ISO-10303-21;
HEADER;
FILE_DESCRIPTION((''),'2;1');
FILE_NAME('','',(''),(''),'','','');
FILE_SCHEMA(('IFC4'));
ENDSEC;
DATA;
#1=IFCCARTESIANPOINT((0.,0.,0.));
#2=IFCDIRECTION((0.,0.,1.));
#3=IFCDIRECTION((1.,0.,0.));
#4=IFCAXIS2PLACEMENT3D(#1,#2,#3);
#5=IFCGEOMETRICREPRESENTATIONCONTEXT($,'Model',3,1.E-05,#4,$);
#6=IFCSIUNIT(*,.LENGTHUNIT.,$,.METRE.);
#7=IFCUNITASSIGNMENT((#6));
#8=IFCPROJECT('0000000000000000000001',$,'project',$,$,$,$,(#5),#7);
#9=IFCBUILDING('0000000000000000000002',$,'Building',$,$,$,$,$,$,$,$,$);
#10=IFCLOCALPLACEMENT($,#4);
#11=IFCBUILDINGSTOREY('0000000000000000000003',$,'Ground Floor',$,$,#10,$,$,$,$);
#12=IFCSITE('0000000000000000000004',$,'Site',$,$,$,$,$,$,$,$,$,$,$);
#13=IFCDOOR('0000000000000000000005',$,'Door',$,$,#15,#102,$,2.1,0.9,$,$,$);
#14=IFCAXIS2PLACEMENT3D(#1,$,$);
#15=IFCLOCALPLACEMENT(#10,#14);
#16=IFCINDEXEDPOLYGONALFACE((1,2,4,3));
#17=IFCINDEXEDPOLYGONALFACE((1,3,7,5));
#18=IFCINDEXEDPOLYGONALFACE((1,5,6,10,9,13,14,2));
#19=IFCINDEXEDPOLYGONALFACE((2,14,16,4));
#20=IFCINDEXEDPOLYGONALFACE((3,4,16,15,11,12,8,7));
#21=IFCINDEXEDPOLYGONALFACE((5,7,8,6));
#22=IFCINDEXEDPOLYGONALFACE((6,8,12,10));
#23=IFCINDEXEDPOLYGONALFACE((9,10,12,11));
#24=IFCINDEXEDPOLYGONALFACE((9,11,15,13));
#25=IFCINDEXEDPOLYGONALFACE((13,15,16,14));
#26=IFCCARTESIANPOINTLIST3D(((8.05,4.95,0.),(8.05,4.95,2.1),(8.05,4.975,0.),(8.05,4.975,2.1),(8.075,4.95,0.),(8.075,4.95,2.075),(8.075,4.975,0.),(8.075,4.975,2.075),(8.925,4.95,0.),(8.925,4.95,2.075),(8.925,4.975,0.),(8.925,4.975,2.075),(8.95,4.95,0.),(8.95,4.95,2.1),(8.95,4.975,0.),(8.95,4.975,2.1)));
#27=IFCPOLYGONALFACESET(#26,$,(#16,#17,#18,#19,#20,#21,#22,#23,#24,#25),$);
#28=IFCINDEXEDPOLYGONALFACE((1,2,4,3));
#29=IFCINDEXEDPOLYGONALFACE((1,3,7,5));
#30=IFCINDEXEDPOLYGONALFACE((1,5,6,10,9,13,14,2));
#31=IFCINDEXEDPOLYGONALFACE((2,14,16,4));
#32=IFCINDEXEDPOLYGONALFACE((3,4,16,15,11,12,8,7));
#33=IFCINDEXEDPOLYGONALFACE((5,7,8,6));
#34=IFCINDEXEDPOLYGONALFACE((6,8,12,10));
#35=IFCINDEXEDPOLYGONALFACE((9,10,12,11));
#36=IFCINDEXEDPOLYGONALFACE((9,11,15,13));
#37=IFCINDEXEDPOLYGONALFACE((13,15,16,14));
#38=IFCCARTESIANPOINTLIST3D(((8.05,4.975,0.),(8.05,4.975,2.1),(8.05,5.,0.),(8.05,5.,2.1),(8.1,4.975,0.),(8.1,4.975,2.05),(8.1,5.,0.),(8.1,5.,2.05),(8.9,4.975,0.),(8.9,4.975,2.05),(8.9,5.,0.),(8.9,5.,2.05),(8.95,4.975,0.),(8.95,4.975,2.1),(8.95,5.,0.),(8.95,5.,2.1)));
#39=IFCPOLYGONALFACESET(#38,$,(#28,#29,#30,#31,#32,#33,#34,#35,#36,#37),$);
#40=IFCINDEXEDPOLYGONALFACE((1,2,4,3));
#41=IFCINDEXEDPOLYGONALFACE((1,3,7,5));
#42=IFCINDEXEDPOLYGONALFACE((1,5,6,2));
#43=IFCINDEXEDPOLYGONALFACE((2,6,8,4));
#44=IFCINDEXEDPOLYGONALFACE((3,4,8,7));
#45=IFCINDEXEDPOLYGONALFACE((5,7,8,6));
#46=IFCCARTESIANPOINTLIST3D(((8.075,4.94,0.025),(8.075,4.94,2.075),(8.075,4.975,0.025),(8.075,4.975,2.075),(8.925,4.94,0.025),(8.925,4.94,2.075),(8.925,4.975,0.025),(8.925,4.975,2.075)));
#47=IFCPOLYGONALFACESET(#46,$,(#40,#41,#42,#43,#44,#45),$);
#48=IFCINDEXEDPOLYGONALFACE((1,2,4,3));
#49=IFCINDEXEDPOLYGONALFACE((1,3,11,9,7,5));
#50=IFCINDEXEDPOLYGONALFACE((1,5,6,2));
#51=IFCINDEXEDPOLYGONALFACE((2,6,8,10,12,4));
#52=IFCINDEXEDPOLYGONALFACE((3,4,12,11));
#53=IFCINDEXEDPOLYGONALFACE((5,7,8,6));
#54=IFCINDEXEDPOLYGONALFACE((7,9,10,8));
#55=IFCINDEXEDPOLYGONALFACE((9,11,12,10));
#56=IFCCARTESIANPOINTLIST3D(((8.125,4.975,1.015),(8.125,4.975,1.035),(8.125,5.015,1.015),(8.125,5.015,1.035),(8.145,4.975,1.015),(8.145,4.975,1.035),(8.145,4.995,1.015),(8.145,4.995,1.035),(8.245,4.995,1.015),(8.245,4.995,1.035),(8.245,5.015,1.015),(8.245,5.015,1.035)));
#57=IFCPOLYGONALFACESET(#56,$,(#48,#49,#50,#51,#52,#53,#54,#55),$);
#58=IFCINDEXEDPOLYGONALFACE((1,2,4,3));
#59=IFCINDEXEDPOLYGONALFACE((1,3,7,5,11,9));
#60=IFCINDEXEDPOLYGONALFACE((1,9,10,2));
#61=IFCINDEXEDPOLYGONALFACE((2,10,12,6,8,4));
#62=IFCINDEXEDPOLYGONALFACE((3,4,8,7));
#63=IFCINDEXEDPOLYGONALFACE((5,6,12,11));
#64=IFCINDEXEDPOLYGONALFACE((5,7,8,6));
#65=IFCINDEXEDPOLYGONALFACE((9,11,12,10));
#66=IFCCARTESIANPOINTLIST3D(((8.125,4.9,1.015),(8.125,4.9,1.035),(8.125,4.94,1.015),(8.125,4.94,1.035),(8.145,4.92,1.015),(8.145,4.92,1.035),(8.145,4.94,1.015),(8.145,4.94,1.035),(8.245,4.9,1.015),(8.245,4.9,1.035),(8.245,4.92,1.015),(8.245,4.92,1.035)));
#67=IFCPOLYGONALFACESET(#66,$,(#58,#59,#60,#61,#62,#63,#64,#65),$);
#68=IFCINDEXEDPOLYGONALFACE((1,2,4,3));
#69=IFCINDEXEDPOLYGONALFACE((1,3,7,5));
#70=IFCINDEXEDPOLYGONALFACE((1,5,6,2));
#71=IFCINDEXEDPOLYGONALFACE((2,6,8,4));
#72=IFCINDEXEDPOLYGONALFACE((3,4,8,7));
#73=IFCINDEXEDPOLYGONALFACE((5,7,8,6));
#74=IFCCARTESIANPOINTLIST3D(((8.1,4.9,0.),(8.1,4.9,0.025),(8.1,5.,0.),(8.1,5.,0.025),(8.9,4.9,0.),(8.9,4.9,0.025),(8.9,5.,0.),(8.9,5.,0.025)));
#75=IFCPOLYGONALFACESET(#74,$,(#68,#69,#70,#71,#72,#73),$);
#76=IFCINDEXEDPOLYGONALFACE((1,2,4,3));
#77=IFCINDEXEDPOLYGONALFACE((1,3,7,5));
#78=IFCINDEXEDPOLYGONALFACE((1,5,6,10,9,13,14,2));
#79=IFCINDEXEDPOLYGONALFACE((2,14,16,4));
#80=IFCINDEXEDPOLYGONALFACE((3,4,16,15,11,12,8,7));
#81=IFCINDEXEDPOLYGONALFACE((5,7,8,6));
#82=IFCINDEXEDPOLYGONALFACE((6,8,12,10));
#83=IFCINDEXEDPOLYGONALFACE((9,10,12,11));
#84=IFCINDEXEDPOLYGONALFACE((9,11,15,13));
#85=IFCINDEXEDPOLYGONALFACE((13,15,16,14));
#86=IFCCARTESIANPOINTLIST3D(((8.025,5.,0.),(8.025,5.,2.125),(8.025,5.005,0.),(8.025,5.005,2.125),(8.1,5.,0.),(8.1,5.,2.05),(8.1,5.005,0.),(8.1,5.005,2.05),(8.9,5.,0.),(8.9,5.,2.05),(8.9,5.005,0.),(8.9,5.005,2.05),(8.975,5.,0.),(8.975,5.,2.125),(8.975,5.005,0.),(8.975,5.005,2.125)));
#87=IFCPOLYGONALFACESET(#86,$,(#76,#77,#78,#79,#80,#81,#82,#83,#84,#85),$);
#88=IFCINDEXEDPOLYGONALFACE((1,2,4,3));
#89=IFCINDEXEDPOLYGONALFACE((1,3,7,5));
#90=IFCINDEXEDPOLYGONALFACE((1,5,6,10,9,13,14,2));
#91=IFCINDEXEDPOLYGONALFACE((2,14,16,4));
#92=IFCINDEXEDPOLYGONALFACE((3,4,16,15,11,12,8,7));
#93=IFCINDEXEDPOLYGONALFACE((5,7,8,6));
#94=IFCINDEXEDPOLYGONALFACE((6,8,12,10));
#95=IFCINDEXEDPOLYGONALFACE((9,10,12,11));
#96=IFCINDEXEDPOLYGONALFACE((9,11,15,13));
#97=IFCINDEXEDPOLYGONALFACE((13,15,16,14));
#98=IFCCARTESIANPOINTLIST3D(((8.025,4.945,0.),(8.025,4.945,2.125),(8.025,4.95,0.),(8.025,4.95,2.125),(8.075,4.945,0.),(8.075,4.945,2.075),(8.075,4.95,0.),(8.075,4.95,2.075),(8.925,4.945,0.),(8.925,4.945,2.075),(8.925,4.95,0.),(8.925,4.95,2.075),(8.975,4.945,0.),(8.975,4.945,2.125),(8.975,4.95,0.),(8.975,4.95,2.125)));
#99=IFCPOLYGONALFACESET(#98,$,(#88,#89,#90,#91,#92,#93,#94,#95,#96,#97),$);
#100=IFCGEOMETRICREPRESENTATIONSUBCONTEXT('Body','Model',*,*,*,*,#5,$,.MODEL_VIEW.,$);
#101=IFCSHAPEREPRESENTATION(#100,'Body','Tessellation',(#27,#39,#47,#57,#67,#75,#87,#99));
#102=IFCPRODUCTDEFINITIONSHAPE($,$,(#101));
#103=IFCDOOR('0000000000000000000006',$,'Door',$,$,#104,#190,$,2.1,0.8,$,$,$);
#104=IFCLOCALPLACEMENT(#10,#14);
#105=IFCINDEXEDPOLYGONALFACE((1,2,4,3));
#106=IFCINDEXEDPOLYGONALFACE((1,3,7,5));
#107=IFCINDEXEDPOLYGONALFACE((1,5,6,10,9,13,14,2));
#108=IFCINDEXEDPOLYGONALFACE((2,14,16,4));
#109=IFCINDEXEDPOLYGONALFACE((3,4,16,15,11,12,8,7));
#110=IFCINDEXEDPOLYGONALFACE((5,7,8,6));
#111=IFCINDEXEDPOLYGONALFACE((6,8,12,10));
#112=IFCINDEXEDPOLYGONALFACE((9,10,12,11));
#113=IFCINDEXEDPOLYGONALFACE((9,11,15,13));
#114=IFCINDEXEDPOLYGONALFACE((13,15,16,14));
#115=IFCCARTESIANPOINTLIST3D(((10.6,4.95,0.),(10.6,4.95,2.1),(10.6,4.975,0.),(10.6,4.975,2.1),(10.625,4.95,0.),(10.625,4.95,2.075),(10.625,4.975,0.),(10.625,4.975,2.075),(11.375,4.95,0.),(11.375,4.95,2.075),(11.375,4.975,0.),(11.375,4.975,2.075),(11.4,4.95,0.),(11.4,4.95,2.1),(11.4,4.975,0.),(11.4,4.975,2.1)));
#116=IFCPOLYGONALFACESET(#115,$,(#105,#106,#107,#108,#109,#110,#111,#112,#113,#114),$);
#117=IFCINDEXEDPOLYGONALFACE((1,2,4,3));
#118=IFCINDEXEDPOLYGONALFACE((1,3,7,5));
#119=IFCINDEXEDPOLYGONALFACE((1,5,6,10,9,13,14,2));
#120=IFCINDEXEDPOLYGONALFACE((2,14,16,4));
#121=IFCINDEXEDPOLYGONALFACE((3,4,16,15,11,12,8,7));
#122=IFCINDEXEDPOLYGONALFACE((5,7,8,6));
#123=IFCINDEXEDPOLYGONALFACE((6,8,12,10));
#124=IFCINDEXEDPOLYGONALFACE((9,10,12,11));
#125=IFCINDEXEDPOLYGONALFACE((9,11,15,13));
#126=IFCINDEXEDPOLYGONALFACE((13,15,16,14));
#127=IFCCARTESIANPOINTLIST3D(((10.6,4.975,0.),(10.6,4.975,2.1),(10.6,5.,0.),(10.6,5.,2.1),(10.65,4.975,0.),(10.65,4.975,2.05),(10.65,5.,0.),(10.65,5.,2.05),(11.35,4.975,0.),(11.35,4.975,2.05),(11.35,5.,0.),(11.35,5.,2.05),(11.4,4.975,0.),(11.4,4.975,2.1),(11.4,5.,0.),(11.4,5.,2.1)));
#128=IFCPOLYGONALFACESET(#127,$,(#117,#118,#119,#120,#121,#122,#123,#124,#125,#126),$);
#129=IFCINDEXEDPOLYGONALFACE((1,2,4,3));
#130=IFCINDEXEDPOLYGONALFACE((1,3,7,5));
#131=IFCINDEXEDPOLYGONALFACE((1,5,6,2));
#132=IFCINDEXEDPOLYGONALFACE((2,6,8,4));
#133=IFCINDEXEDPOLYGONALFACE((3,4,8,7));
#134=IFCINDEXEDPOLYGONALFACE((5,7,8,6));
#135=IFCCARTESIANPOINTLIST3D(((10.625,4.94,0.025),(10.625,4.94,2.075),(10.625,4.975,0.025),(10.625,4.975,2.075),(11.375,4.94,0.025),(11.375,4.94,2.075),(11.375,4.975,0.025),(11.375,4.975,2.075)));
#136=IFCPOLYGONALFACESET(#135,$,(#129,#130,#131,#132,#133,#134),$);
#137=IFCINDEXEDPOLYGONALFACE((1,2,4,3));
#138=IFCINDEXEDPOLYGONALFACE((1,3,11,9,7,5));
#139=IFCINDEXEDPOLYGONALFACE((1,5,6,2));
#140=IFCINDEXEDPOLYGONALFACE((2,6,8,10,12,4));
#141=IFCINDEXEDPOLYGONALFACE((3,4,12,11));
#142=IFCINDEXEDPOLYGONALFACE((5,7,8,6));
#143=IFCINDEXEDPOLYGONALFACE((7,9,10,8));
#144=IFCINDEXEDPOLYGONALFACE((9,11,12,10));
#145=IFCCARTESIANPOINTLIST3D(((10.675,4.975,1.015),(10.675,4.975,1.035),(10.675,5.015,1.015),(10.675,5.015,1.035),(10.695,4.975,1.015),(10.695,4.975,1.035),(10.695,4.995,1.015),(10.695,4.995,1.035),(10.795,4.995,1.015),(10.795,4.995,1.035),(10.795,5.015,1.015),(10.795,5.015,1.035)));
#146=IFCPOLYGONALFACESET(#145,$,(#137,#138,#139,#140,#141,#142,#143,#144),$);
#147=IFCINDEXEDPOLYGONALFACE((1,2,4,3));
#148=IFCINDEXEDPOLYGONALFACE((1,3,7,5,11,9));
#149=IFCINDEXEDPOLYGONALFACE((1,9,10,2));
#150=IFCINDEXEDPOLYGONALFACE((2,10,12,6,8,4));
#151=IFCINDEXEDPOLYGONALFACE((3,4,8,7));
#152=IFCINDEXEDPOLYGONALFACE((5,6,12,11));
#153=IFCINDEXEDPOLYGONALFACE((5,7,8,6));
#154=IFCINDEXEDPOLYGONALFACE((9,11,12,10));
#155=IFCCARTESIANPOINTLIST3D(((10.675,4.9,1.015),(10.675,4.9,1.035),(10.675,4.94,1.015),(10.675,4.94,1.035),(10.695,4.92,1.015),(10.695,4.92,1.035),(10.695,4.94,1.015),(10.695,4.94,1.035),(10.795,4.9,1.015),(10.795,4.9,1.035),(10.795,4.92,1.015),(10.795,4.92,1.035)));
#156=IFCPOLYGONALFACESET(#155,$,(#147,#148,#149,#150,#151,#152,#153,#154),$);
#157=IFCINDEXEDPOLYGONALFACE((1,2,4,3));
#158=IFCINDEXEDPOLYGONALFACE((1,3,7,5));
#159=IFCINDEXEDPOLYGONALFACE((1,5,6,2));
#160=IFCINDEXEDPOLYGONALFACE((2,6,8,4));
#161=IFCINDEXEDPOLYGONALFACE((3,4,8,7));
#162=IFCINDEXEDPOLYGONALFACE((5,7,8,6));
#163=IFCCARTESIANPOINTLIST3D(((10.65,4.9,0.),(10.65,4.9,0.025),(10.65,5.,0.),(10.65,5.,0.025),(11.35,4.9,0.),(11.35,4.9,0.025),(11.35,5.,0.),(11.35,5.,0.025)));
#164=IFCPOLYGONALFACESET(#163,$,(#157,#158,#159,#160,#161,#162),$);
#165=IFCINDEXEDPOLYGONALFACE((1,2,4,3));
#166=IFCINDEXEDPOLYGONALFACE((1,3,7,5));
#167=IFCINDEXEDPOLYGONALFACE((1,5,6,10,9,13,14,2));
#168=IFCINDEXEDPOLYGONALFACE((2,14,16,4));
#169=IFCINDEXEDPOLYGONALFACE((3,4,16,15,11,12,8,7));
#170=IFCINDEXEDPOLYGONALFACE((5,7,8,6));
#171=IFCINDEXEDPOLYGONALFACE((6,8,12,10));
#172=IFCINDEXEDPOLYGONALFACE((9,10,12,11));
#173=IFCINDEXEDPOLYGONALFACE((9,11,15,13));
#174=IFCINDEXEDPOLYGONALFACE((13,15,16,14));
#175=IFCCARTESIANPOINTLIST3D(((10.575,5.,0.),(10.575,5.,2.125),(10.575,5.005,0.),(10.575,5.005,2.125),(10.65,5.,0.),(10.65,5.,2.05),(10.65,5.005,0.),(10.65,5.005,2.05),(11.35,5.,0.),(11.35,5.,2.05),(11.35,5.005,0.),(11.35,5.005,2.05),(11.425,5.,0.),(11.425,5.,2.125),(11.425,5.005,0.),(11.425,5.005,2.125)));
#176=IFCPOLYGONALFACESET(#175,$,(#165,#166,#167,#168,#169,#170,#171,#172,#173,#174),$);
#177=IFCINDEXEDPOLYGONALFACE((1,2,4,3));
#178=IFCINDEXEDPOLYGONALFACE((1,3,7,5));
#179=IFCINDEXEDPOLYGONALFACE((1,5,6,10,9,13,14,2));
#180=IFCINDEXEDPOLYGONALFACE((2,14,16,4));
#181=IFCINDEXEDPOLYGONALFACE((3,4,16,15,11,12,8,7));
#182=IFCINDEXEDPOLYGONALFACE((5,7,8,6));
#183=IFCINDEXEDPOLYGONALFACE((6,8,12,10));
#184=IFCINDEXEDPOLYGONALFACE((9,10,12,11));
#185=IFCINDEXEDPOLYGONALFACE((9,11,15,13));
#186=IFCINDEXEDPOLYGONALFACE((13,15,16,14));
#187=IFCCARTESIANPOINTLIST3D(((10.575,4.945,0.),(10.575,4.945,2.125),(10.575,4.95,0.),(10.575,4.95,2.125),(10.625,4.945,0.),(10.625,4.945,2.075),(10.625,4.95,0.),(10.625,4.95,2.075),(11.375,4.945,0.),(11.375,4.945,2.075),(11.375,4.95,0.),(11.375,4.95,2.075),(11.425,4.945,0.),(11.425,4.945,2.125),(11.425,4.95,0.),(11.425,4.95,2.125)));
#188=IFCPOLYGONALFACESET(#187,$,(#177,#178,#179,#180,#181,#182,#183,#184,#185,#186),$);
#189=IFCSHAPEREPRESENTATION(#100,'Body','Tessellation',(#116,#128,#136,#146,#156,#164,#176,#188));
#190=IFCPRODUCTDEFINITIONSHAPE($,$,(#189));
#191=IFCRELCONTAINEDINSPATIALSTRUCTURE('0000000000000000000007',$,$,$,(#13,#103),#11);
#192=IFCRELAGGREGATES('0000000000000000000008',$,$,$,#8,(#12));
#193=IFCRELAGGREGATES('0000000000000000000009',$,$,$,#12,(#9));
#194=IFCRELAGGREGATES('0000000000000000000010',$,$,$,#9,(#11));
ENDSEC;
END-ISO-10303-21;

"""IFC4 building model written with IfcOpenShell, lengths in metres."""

from ifc_helpers import new_model, si_unit, frame, origin_with_axes, place, context, subcontext, project, spatial, line, indexed_curve, outline, extrude, element, save


model = new_model("IFC4")

# Units and contexts
model_context = context("Model", 3, precision=1e-05, world=origin_with_axes())
body_context = subcontext(model_context, "Body", "Model", "MODEL_VIEW")
ifc_project = project(units=[si_unit("LENGTHUNIT", "METRE")], contexts=[model_context])

# Site, building, storey
site = spatial("IfcSite", under=ifc_project, Name="Site")
building = spatial("IfcBuilding", under=site, Name="Building")
storey_placement = place(None, origin_with_axes())
storey = spatial("IfcBuildingStorey", under=building, at=storey_placement, Name="Ground Floor")

# Doors
door_1_placement = place(storey_placement, frame((8.95, 5.0, 0.0), z_axis=(0.0, 0.0, 1.0), x_axis=(-1.0, 0.0, 0.0)))
element("IfcDoor", 1, at=door_1_placement, inside=storey, Name="Door", OverallHeight=2.1, OverallWidth=0.9, context=body_context, shape_type="SweptSolid", body=[
    extrude(outline(indexed_curve([(0.0, 0.0), (0.0, 2.1), (0.9, 2.1), (0.9, 0.0), (0.875, 0.0), (0.875, 2.075), (0.025, 2.075), (0.025, 0.0)], segments=[line(1, 2, 3, 4, 5, 6, 7, 8, 1)])), frame((0.0, 0.025, 0.0), z_axis=(0.0, -1.0, 0.0), x_axis=(1.0, 0.0, 0.0)), (0.0, 0.0, -1.0), 0.025),
    extrude(outline(indexed_curve([(0.0, 0.0), (0.0, 2.1), (0.9, 2.1), (0.9, 0.0), (0.85, 0.0), (0.85, 2.05), (0.05, 2.05), (0.05, 0.0)], segments=[line(1, 2, 3, 4, 5, 6, 7, 8, 1)])), frame((0.0, 0.0, 0.0), z_axis=(0.0, -1.0, 0.0), x_axis=(1.0, 0.0, 0.0)), (0.0, 0.0, -1.0), 0.025),
    extrude(outline(indexed_curve([(0.0, 0.0), (0.85, 0.0), (0.85, 0.035), (0.0, 0.035)], segments=[line(1, 2, 3, 4, 1)])), frame((0.025, 0.025, 0.025), z_axis=(0.0, 0.0, 1.0), x_axis=(1.0, 0.0, 0.0)), (0.0, 0.0, 1.0), 2.05),
    extrude(outline(indexed_curve([(0.0, 0.0), (0.0, -0.04), (-0.12, -0.04), (-0.12, -0.02), (-0.02, -0.02), (-0.02, 0.0)], segments=[line(1, 2, 3, 4, 5, 6, 1)])), frame((0.825, 0.025, 1.015), z_axis=(0.0, 0.0, 1.0), x_axis=(1.0, 0.0, 0.0)), (0.0, 0.0, 1.0), 0.02),
    extrude(outline(indexed_curve([(0.0, 0.0), (0.0, 0.04), (-0.12, 0.04), (-0.12, 0.02), (-0.02, 0.02), (-0.02, 0.0)], segments=[line(1, 2, 3, 4, 5, 6, 1)])), frame((0.825, 0.06, 1.015), z_axis=(0.0, 0.0, 1.0), x_axis=(1.0, 0.0, 0.0)), (0.0, 0.0, 1.0), 0.02),
    extrude(outline(indexed_curve([(0.0, 0.0), (0.8, 0.0), (0.8, 0.1), (0.0, 0.1)], segments=[line(1, 2, 3, 4, 1)])), frame((0.05, 0.0, 0.0), z_axis=(0.0, 0.0, 1.0), x_axis=(1.0, 0.0, 0.0)), (0.0, 0.0, 1.0), 0.025),
    extrude(outline(indexed_curve([(0.0, 0.0), (0.0, 2.125), (0.95, 2.125), (0.95, 0.0), (0.875, 0.0), (0.875, 2.05), (0.075, 2.05), (0.075, 0.0)], segments=[line(1, 2, 3, 4, 5, 6, 7, 8, 1)])), frame((-0.025, -0.005, 0.0), z_axis=(0.0, -1.0, 0.0), x_axis=(1.0, 0.0, 0.0)), (0.0, 0.0, -1.0), 0.005),
    extrude(outline(indexed_curve([(0.0, 0.0), (0.0, 2.125), (0.95, 2.125), (0.95, 0.0), (0.9, 0.0), (0.9, 2.075), (0.05, 2.075), (0.05, 0.0)], segments=[line(1, 2, 3, 4, 5, 6, 7, 8, 1)])), frame((-0.025, 0.05, 0.0), z_axis=(0.0, -1.0, 0.0), x_axis=(1.0, 0.0, 0.0)), (0.0, 0.0, -1.0), 0.005),
])
door_2_placement = place(storey_placement, frame((11.4, 5.0, 0.0), z_axis=(0.0, 0.0, 1.0), x_axis=(-1.0, 0.0, 0.0)))
element("IfcDoor", 2, at=door_2_placement, inside=storey, Name="Door", OverallHeight=2.1, OverallWidth=0.8, context=body_context, shape_type="SweptSolid", body=[
    extrude(outline(indexed_curve([(0.0, 0.0), (0.0, 2.1), (0.8, 2.1), (0.8, 0.0), (0.775, 0.0), (0.775, 2.075), (0.025, 2.075), (0.025, 0.0)], segments=[line(1, 2, 3, 4, 5, 6, 7, 8, 1)])), frame((0.0, 0.025, 0.0), z_axis=(0.0, -1.0, 0.0), x_axis=(1.0, 0.0, 0.0)), (0.0, 0.0, -1.0), 0.025),
    extrude(outline(indexed_curve([(0.0, 0.0), (0.0, 2.1), (0.8, 2.1), (0.8, 0.0), (0.75, 0.0), (0.75, 2.05), (0.05, 2.05), (0.05, 0.0)], segments=[line(1, 2, 3, 4, 5, 6, 7, 8, 1)])), frame((0.0, 0.0, 0.0), z_axis=(0.0, -1.0, 0.0), x_axis=(1.0, 0.0, 0.0)), (0.0, 0.0, -1.0), 0.025),
    extrude(outline(indexed_curve([(0.0, 0.0), (0.75, 0.0), (0.75, 0.035), (0.0, 0.035)], segments=[line(1, 2, 3, 4, 1)])), frame((0.025, 0.025, 0.025), z_axis=(0.0, 0.0, 1.0), x_axis=(1.0, 0.0, 0.0)), (0.0, 0.0, 1.0), 2.05),
    extrude(outline(indexed_curve([(0.0, 0.0), (0.0, -0.04), (-0.12, -0.04), (-0.12, -0.02), (-0.02, -0.02), (-0.02, 0.0)], segments=[line(1, 2, 3, 4, 5, 6, 1)])), frame((0.725, 0.025, 1.015), z_axis=(0.0, 0.0, 1.0), x_axis=(1.0, 0.0, 0.0)), (0.0, 0.0, 1.0), 0.02),
    extrude(outline(indexed_curve([(0.0, 0.0), (0.0, 0.04), (-0.12, 0.04), (-0.12, 0.02), (-0.02, 0.02), (-0.02, 0.0)], segments=[line(1, 2, 3, 4, 5, 6, 1)])), frame((0.725, 0.06, 1.015), z_axis=(0.0, 0.0, 1.0), x_axis=(1.0, 0.0, 0.0)), (0.0, 0.0, 1.0), 0.02),
    extrude(outline(indexed_curve([(0.0, 0.0), (0.7, 0.0), (0.7, 0.1), (0.0, 0.1)], segments=[line(1, 2, 3, 4, 1)])), frame((0.05, 0.0, 0.0), z_axis=(0.0, 0.0, 1.0), x_axis=(1.0, 0.0, 0.0)), (0.0, 0.0, 1.0), 0.025),
    extrude(outline(indexed_curve([(0.0, 0.0), (0.0, 2.125), (0.85, 2.125), (0.85, 0.0), (0.775, 0.0), (0.775, 2.05), (0.075, 2.05), (0.075, 0.0)], segments=[line(1, 2, 3, 4, 5, 6, 7, 8, 1)])), frame((-0.025, -0.005, 0.0), z_axis=(0.0, -1.0, 0.0), x_axis=(1.0, 0.0, 0.0)), (0.0, 0.0, -1.0), 0.005),
    extrude(outline(indexed_curve([(0.0, 0.0), (0.0, 2.125), (0.85, 2.125), (0.85, 0.0), (0.8, 0.0), (0.8, 2.075), (0.05, 2.075), (0.05, 0.0)], segments=[line(1, 2, 3, 4, 5, 6, 7, 8, 1)])), frame((-0.025, 0.05, 0.0), z_axis=(0.0, -1.0, 0.0), x_axis=(1.0, 0.0, 0.0)), (0.0, 0.0, -1.0), 0.005),
])

save(model, "model.ifc")
